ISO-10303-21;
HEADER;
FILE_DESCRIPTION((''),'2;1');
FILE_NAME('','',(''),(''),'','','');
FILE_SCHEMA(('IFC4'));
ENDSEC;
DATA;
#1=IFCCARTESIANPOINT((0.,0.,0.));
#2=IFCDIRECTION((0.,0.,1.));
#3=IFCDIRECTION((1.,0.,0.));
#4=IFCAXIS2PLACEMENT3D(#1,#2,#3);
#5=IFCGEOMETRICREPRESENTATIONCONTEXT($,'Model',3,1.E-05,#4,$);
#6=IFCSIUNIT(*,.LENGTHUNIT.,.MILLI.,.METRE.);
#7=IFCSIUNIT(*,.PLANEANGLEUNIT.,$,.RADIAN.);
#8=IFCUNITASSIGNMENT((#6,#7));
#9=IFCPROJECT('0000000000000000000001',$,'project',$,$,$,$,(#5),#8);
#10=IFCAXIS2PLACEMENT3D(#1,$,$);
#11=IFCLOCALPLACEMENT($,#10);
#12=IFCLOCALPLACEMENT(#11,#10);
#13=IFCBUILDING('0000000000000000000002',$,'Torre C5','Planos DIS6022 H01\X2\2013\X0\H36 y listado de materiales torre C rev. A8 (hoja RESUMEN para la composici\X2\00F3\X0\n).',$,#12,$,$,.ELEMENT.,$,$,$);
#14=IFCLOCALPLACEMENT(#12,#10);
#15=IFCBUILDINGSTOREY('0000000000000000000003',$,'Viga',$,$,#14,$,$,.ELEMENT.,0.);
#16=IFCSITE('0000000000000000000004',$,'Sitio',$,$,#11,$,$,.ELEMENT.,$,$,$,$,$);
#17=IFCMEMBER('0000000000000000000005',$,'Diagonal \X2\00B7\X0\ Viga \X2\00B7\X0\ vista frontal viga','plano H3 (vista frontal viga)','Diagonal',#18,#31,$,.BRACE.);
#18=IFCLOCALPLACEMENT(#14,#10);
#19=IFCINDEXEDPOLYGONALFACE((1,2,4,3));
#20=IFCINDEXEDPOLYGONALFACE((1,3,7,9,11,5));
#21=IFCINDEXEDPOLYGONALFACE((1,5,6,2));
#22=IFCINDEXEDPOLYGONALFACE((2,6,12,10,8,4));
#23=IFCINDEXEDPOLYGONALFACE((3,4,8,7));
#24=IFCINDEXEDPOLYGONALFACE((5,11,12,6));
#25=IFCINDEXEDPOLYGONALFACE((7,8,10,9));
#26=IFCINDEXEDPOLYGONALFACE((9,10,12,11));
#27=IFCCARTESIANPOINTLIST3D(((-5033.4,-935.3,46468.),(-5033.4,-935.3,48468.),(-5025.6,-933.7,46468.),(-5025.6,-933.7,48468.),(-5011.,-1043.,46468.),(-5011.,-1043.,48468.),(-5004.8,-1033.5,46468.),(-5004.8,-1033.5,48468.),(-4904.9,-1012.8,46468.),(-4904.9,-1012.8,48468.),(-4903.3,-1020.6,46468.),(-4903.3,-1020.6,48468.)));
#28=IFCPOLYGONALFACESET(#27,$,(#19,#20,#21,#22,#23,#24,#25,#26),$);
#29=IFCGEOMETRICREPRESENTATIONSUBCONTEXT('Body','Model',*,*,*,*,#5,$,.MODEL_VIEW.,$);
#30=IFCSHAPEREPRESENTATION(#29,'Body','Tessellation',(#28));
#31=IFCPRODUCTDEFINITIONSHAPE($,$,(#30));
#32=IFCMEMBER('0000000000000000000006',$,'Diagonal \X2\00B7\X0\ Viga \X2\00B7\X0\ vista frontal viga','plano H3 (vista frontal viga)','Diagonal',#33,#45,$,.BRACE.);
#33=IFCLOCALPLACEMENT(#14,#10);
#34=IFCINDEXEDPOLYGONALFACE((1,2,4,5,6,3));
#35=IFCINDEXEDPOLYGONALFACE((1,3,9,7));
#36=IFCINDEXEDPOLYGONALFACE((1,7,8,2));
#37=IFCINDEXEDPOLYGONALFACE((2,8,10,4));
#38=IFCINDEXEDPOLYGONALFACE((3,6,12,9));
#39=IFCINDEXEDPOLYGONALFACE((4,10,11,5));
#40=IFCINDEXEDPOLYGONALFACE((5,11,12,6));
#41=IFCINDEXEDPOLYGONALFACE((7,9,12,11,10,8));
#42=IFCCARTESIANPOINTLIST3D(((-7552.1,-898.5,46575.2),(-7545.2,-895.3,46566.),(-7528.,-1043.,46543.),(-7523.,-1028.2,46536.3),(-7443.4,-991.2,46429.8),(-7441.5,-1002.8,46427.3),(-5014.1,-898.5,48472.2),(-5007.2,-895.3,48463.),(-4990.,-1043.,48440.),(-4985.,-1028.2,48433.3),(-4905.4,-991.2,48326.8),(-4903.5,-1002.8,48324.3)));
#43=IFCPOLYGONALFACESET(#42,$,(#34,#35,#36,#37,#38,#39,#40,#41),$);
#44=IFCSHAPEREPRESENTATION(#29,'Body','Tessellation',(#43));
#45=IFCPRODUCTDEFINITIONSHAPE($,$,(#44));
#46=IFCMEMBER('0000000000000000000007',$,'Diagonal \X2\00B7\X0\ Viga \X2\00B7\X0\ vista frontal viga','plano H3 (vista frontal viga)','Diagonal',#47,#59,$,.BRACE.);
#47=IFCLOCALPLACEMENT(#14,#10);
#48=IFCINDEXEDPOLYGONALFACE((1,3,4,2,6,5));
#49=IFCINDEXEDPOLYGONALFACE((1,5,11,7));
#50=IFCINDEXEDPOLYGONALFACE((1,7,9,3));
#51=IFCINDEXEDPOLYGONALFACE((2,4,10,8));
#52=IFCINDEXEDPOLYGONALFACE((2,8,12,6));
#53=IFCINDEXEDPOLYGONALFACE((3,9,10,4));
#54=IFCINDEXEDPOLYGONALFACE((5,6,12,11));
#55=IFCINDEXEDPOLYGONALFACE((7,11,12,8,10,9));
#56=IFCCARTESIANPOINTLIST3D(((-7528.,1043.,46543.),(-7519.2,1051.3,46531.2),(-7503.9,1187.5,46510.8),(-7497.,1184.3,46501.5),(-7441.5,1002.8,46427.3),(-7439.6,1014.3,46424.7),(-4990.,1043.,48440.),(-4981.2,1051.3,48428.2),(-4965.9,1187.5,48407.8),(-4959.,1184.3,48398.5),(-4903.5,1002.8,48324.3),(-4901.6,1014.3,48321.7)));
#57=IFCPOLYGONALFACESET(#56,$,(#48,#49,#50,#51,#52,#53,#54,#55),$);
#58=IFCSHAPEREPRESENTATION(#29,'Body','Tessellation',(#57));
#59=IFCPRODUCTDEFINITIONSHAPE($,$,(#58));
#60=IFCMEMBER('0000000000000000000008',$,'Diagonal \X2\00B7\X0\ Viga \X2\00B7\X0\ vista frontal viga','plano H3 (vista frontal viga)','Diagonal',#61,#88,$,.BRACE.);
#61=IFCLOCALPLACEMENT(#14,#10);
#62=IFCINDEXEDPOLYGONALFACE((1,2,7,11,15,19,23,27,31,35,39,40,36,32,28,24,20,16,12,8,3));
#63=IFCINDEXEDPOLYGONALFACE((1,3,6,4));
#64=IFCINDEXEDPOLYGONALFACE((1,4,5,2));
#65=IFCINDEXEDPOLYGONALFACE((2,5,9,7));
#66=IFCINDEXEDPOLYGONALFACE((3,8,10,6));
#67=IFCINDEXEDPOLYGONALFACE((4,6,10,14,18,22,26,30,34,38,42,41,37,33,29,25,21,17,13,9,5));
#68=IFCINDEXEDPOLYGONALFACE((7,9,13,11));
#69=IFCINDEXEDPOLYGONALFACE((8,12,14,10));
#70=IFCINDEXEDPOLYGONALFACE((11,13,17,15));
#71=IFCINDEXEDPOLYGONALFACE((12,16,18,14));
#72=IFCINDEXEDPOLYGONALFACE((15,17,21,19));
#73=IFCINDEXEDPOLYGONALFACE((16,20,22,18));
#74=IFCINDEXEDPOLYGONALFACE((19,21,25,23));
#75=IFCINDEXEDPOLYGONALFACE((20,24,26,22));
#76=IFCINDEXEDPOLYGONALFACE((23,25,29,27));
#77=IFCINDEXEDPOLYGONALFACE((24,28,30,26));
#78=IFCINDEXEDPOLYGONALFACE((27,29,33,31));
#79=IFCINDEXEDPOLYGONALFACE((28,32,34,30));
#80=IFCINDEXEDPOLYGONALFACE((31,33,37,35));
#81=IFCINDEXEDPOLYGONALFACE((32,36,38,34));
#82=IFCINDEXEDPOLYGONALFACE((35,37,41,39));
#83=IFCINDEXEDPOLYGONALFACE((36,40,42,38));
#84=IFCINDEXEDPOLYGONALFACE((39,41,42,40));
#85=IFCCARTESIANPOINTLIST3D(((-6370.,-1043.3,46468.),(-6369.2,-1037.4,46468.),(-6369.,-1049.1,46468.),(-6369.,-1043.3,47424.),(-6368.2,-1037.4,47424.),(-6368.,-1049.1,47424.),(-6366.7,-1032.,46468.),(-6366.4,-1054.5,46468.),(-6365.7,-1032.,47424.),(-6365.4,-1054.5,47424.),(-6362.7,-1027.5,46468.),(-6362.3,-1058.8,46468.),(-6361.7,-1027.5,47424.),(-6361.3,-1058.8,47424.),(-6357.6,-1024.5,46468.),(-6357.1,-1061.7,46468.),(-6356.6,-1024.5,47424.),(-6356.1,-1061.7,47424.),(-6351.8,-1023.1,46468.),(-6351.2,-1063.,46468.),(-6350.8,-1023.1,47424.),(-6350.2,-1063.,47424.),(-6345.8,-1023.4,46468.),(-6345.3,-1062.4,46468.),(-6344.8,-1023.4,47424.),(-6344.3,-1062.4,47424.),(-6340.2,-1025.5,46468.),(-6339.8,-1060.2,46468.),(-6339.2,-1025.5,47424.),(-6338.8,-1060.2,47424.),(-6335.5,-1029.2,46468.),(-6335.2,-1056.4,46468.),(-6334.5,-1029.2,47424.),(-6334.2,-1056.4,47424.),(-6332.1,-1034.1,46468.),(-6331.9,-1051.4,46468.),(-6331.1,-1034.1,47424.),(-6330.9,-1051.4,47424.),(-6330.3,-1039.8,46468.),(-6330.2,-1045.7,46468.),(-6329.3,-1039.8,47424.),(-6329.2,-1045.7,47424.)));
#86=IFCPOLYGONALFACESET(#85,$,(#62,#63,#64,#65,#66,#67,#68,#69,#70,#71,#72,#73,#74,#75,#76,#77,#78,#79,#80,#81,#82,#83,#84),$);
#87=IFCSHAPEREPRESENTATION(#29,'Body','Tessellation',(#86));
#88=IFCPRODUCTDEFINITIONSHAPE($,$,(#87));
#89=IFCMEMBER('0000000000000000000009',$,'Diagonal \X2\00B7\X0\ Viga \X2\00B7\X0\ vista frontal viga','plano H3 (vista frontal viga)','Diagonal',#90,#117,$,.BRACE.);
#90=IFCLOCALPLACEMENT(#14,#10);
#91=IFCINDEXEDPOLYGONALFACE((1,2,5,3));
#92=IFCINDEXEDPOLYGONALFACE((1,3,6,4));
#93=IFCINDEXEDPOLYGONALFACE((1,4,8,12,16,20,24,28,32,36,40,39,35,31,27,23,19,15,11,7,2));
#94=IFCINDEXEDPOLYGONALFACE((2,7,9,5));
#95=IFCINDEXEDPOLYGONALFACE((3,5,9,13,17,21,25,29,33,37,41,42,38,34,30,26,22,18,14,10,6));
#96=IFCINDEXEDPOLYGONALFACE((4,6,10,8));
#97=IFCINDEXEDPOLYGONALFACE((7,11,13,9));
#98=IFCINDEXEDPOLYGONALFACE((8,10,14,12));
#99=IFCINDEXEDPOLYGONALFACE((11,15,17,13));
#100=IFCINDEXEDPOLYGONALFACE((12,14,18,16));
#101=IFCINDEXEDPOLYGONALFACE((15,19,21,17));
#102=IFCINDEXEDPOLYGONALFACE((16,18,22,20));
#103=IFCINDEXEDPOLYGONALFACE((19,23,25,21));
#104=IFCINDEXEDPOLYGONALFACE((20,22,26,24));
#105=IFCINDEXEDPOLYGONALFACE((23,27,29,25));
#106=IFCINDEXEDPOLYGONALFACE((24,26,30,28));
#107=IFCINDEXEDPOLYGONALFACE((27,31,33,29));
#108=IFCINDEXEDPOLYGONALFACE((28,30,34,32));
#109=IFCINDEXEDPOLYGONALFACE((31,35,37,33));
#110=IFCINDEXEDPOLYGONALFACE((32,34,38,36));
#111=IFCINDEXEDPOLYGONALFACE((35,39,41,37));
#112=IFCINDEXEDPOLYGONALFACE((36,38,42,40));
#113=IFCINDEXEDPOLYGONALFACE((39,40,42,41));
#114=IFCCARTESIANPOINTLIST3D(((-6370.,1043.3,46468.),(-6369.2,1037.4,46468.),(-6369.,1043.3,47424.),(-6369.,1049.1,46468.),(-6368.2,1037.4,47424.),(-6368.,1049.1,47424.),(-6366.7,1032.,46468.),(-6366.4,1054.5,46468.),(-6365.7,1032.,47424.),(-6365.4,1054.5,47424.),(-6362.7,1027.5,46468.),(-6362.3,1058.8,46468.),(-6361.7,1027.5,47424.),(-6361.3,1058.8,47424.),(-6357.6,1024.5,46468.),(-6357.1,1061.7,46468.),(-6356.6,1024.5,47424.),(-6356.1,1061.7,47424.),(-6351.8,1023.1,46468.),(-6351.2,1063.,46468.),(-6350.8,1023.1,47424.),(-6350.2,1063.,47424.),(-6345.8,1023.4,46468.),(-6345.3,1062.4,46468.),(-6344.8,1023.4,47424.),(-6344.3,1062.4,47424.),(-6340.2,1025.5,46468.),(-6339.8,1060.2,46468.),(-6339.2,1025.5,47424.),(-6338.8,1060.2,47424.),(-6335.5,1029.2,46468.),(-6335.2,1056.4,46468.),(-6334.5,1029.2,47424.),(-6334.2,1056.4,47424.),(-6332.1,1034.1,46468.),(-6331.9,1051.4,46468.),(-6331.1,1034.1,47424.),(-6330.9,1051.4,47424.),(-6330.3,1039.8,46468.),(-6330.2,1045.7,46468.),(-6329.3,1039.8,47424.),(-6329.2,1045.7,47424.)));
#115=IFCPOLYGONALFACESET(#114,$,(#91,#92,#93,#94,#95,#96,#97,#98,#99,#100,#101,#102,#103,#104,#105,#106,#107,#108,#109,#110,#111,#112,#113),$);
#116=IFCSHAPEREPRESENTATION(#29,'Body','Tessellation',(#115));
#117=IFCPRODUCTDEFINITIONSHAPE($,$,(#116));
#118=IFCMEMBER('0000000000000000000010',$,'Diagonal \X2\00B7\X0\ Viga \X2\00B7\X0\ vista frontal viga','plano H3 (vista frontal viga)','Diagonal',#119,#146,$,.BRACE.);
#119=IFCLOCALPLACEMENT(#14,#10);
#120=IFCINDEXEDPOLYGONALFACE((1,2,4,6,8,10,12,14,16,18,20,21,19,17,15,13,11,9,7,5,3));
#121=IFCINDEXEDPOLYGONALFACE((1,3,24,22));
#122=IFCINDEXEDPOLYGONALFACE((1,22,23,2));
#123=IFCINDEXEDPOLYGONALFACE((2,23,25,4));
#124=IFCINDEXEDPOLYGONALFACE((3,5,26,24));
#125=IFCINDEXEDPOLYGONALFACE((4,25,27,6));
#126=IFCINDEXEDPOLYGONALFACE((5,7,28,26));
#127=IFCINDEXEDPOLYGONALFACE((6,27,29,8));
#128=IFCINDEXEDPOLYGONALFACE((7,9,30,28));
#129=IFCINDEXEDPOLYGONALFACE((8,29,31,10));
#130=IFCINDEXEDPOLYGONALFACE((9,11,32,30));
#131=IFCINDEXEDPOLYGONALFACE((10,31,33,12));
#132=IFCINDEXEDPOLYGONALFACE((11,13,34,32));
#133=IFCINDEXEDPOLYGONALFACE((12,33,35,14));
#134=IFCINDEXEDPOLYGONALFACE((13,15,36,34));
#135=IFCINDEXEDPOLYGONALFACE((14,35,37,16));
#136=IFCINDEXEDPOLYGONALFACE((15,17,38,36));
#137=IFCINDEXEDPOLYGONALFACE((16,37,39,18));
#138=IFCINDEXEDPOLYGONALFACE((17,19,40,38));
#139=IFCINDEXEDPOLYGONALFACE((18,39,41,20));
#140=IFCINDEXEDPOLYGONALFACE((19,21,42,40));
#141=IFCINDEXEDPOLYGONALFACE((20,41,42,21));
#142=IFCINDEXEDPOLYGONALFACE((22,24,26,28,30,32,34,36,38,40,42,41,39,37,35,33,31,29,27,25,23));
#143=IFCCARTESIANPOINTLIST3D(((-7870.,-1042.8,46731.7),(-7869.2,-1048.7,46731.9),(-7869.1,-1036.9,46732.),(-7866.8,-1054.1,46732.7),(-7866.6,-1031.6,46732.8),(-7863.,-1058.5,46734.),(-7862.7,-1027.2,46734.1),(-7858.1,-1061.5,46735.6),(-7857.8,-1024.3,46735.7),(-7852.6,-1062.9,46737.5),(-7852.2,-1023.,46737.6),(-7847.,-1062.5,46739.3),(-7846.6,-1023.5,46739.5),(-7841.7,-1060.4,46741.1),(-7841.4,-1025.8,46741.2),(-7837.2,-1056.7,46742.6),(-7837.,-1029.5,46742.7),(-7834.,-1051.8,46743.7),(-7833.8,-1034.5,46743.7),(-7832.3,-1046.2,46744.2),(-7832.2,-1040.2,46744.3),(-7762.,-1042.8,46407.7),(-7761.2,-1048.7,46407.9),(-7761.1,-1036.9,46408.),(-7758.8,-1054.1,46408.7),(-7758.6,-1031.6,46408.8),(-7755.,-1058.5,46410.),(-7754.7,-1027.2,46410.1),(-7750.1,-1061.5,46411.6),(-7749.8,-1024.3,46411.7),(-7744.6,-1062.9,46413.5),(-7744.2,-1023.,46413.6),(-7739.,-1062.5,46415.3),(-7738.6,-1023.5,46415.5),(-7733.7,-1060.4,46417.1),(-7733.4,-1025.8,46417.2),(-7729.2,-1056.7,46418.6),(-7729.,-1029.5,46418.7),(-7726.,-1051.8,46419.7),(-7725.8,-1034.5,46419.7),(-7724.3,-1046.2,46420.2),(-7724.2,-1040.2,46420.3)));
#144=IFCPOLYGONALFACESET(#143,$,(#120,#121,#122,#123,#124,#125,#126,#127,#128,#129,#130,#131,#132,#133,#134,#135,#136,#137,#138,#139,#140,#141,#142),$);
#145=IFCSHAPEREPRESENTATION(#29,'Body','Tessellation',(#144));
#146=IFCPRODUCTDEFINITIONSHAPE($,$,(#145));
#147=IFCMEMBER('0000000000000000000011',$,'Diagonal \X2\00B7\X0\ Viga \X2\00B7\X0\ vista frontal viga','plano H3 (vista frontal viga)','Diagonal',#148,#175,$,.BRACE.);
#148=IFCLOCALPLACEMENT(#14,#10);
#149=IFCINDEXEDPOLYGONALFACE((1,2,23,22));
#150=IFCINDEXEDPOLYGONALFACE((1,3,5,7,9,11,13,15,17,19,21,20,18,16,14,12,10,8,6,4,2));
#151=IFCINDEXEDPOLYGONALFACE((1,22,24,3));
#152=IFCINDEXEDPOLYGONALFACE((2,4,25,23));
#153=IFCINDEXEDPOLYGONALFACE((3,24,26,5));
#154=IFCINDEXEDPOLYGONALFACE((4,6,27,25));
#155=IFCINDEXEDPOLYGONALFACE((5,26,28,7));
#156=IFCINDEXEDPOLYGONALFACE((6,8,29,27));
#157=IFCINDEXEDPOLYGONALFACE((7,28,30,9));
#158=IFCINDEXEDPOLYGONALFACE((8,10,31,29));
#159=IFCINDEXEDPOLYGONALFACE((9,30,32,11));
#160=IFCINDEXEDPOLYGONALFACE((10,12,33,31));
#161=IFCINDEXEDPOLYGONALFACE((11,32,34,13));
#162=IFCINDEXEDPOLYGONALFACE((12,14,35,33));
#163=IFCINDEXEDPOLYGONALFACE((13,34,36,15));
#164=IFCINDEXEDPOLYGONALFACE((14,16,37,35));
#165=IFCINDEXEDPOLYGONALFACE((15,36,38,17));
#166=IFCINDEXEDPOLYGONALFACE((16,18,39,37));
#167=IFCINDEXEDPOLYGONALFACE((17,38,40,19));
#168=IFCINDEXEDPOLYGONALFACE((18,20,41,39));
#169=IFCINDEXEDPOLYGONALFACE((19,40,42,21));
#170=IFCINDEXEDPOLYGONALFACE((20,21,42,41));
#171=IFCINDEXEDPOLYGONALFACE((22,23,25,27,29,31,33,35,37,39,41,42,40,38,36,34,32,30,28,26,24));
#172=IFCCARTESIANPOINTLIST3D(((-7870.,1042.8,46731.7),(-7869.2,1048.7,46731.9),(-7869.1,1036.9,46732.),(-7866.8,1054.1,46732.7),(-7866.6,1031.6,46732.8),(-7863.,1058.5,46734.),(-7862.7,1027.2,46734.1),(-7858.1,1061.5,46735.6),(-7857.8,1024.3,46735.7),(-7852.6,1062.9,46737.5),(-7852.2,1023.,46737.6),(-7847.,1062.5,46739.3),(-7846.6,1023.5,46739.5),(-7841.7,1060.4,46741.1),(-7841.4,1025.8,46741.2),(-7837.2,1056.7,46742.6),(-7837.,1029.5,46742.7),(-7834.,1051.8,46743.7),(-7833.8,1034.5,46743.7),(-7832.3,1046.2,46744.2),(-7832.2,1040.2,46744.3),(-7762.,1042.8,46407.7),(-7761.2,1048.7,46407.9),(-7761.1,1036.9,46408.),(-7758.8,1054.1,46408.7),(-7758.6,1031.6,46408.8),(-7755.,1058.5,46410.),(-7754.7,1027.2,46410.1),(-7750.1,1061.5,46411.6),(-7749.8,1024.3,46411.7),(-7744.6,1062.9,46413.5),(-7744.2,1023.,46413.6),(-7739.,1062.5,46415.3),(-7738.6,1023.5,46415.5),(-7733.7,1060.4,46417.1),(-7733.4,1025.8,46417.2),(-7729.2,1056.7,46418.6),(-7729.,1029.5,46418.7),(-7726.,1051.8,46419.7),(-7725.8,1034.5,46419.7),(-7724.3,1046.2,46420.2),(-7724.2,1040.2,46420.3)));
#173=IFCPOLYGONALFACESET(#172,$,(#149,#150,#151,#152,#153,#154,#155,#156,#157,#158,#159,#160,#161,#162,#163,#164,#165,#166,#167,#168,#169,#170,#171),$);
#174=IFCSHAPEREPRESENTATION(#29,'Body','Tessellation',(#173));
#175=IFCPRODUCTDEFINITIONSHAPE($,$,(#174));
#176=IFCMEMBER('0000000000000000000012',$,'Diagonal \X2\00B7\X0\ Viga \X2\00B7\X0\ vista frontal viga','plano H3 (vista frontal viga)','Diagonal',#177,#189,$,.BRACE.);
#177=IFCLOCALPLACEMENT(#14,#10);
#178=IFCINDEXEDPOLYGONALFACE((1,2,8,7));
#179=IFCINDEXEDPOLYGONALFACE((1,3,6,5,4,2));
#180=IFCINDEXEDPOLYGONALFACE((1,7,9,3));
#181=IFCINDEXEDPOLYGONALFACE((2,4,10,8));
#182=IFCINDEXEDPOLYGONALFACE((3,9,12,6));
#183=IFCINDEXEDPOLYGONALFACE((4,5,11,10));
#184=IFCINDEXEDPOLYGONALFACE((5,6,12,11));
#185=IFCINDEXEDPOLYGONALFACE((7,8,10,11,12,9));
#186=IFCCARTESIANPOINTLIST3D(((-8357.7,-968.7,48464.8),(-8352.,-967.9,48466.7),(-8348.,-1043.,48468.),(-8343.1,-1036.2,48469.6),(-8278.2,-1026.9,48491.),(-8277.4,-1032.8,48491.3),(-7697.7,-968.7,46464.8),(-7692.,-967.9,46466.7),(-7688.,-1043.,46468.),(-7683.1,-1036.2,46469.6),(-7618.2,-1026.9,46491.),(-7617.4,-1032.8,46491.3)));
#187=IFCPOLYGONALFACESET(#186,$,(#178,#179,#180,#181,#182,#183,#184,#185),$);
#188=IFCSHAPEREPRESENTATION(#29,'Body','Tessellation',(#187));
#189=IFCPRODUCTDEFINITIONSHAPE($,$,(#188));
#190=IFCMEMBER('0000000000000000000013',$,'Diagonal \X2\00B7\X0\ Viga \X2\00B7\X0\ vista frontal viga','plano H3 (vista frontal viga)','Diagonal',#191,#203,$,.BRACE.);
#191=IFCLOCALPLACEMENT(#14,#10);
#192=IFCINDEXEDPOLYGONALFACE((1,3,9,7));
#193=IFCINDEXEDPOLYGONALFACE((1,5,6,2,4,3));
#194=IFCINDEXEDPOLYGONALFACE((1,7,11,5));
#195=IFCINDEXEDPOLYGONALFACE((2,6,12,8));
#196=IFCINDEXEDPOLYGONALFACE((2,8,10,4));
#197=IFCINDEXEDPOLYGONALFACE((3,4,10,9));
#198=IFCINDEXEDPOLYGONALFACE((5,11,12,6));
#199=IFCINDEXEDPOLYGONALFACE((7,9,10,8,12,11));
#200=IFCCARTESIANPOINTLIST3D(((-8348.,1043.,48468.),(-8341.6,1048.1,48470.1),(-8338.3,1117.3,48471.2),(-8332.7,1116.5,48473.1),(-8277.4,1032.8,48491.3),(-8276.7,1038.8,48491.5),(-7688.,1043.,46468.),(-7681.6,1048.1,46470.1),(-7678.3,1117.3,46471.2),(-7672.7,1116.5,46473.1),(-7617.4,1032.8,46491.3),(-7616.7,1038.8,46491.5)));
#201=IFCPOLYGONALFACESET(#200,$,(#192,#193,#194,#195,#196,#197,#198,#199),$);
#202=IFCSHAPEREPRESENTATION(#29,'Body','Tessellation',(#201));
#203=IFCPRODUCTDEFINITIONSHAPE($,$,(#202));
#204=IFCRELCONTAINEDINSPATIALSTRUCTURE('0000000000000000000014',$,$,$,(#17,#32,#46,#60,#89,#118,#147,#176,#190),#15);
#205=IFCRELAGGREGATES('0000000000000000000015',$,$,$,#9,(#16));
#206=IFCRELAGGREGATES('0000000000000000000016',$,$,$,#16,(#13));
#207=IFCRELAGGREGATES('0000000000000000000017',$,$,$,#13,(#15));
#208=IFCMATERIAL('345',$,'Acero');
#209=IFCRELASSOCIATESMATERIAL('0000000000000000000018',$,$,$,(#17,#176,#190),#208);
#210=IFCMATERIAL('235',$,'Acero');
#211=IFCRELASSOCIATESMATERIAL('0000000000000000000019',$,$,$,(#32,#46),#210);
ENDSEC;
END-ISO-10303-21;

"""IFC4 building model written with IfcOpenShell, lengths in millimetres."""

from ifc_helpers import new_model, si_unit, frame, frame_2d, origin, origin_with_axes, place, context, subcontext, project, spatial, circle, l_section, extrude, material, element, save


model = new_model("IFC4")

# Units and contexts
model_context = context("Model", 3, precision=1e-05, world=origin_with_axes())
body_context = subcontext(model_context, "Body", "Model", "MODEL_VIEW")
ifc_project = project(units=[si_unit("LENGTHUNIT", "METRE", prefix="MILLI"), si_unit("PLANEANGLEUNIT", "RADIAN")], contexts=[model_context])

# Site, building, storey
site_placement = place(None, origin())
site = spatial("IfcSite", under=ifc_project, at=site_placement, Name="Sitio", CompositionType="ELEMENT")
building_placement = place(site_placement, origin())
building = spatial("IfcBuilding", under=site, at=building_placement, Name="Torre C5", Description="Planos DIS6022 H01–H36 y listado de materiales torre C rev. A8 (hoja RESUMEN para la composición).", CompositionType="ELEMENT")
storey_placement = place(building_placement, origin())
storey = spatial("IfcBuildingStorey", under=building, at=storey_placement, Name="Viga", CompositionType="ELEMENT", Elevation=0.0)

# Members
ifc_material_1 = material(Name="345", Category="Acero")
member_1_placement = place(storey_placement, frame((-5011.0, -1043.0, 46468.0), z_axis=(0.0, 0.0, 1.0), x_axis=(0.979018, 0.203775, 0.0)))
element("IfcMember", 1, at=member_1_placement, inside=storey, material=ifc_material_1, Name="Diagonal · Viga · vista frontal viga", Description="plano H3 (vista frontal viga)", ObjectType="Diagonal", PredefinedType="BRACE", context=body_context, shape_type="SweptSolid", body=[
    extrude(l_section(Depth=110.0, Width=110.0, Thickness=8.0, at=frame_2d((55.0, 55.0))), None, (0.0, 0.0, 1.0), 2000.0),
])
ifc_material_2 = material(Name="235", Category="Acero")
for number, where, z_axis, x_axis, name in (
    (2, (-7528.0, -1043.0, 46543.0), (0.800984, 0.0, 0.598686), (0.576761, 0.268149, -0.771649), "Diagonal · Viga · vista frontal viga"),
    (3, (-7528.0, 1043.0, 46543.0), (0.800984, 0.0, 0.598686), (0.576761, -0.268149, -0.771649), "Diagonal · Viga · vista frontal viga"),
):
    element("IfcMember", number, at=place(storey_placement, frame(where, z_axis=z_axis, x_axis=x_axis)), inside=storey, material=ifc_material_2, Name=name, Description="plano H3 (vista frontal viga)", ObjectType="Diagonal", PredefinedType="BRACE", context=body_context, shape_type="SweptSolid", body=[
        extrude(l_section(Depth=150.0, Width=150.0, Thickness=12.0, at=frame_2d((75.0, 75.0))), None, (0.0, 0.0, 1.0), 3168.6),
    ])
for number, where, z_axis, x_axis, name in (
    (4, (-6349.0, -1043.0, 47424.0), (-0.001046, 0.0, -0.999999), (0.986775, 0.162093, -0.001032), "Diagonal · Viga · vista frontal viga"),
    (5, (-6349.0, 1043.0, 47424.0), (-0.001046, 0.0, -0.999999), (0.986775, -0.162093, -0.001032), "Diagonal · Viga · vista frontal viga"),
):
    element("IfcMember", number, at=place(storey_placement, frame(where, z_axis=z_axis, x_axis=x_axis)), inside=storey, Name=name, Description="plano H3 (vista frontal viga)", ObjectType="Diagonal", PredefinedType="BRACE", context=body_context, shape_type="SweptSolid", body=[
        extrude(circle(Radius=20.0), None, (0.0, 0.0, 1.0), 956.0),
    ])
for number, where, z_axis, x_axis, name in (
    (6, (-7743.0, -1043.0, 46414.0), (-0.316228, 0.0, 0.948683), (0.939391, 0.139624, 0.31313), "Diagonal · Viga · vista frontal viga"),
    (7, (-7743.0, 1043.0, 46414.0), (-0.316228, 0.0, 0.948683), (0.939391, -0.139624, 0.31313), "Diagonal · Viga · vista frontal viga"),
):
    element("IfcMember", number, at=place(storey_placement, frame(where, z_axis=z_axis, x_axis=x_axis)), inside=storey, Name=name, Description="plano H3 (vista frontal viga)", ObjectType="Diagonal", PredefinedType="BRACE", context=body_context, shape_type="SweptSolid", body=[
        extrude(circle(Radius=20.0), None, (0.0, 0.0, 1.0), 341.5),
    ])
for number, where, z_axis, x_axis, name in (
    (8, (-7688.0, -1043.0, 46468.0), (-0.313377, 0.0, 0.949629), (0.940843, 0.135715, 0.310478), "Diagonal · Viga · vista frontal viga"),
    (9, (-7688.0, 1043.0, 46468.0), (-0.313377, 0.0, 0.949629), (0.940843, -0.135715, 0.310478), "Diagonal · Viga · vista frontal viga"),
):
    element("IfcMember", number, at=place(storey_placement, frame(where, z_axis=z_axis, x_axis=x_axis)), inside=storey, material=ifc_material_1, Name=name, Description="plano H3 (vista frontal viga)", ObjectType="Diagonal", PredefinedType="BRACE", context=body_context, shape_type="SweptSolid", body=[
        extrude(l_section(Depth=75.0, Width=75.0, Thickness=6.0, at=frame_2d((37.5, 37.5))), None, (0.0, 0.0, 1.0), 2106.1),
    ])

save(model, "model.ifc")
